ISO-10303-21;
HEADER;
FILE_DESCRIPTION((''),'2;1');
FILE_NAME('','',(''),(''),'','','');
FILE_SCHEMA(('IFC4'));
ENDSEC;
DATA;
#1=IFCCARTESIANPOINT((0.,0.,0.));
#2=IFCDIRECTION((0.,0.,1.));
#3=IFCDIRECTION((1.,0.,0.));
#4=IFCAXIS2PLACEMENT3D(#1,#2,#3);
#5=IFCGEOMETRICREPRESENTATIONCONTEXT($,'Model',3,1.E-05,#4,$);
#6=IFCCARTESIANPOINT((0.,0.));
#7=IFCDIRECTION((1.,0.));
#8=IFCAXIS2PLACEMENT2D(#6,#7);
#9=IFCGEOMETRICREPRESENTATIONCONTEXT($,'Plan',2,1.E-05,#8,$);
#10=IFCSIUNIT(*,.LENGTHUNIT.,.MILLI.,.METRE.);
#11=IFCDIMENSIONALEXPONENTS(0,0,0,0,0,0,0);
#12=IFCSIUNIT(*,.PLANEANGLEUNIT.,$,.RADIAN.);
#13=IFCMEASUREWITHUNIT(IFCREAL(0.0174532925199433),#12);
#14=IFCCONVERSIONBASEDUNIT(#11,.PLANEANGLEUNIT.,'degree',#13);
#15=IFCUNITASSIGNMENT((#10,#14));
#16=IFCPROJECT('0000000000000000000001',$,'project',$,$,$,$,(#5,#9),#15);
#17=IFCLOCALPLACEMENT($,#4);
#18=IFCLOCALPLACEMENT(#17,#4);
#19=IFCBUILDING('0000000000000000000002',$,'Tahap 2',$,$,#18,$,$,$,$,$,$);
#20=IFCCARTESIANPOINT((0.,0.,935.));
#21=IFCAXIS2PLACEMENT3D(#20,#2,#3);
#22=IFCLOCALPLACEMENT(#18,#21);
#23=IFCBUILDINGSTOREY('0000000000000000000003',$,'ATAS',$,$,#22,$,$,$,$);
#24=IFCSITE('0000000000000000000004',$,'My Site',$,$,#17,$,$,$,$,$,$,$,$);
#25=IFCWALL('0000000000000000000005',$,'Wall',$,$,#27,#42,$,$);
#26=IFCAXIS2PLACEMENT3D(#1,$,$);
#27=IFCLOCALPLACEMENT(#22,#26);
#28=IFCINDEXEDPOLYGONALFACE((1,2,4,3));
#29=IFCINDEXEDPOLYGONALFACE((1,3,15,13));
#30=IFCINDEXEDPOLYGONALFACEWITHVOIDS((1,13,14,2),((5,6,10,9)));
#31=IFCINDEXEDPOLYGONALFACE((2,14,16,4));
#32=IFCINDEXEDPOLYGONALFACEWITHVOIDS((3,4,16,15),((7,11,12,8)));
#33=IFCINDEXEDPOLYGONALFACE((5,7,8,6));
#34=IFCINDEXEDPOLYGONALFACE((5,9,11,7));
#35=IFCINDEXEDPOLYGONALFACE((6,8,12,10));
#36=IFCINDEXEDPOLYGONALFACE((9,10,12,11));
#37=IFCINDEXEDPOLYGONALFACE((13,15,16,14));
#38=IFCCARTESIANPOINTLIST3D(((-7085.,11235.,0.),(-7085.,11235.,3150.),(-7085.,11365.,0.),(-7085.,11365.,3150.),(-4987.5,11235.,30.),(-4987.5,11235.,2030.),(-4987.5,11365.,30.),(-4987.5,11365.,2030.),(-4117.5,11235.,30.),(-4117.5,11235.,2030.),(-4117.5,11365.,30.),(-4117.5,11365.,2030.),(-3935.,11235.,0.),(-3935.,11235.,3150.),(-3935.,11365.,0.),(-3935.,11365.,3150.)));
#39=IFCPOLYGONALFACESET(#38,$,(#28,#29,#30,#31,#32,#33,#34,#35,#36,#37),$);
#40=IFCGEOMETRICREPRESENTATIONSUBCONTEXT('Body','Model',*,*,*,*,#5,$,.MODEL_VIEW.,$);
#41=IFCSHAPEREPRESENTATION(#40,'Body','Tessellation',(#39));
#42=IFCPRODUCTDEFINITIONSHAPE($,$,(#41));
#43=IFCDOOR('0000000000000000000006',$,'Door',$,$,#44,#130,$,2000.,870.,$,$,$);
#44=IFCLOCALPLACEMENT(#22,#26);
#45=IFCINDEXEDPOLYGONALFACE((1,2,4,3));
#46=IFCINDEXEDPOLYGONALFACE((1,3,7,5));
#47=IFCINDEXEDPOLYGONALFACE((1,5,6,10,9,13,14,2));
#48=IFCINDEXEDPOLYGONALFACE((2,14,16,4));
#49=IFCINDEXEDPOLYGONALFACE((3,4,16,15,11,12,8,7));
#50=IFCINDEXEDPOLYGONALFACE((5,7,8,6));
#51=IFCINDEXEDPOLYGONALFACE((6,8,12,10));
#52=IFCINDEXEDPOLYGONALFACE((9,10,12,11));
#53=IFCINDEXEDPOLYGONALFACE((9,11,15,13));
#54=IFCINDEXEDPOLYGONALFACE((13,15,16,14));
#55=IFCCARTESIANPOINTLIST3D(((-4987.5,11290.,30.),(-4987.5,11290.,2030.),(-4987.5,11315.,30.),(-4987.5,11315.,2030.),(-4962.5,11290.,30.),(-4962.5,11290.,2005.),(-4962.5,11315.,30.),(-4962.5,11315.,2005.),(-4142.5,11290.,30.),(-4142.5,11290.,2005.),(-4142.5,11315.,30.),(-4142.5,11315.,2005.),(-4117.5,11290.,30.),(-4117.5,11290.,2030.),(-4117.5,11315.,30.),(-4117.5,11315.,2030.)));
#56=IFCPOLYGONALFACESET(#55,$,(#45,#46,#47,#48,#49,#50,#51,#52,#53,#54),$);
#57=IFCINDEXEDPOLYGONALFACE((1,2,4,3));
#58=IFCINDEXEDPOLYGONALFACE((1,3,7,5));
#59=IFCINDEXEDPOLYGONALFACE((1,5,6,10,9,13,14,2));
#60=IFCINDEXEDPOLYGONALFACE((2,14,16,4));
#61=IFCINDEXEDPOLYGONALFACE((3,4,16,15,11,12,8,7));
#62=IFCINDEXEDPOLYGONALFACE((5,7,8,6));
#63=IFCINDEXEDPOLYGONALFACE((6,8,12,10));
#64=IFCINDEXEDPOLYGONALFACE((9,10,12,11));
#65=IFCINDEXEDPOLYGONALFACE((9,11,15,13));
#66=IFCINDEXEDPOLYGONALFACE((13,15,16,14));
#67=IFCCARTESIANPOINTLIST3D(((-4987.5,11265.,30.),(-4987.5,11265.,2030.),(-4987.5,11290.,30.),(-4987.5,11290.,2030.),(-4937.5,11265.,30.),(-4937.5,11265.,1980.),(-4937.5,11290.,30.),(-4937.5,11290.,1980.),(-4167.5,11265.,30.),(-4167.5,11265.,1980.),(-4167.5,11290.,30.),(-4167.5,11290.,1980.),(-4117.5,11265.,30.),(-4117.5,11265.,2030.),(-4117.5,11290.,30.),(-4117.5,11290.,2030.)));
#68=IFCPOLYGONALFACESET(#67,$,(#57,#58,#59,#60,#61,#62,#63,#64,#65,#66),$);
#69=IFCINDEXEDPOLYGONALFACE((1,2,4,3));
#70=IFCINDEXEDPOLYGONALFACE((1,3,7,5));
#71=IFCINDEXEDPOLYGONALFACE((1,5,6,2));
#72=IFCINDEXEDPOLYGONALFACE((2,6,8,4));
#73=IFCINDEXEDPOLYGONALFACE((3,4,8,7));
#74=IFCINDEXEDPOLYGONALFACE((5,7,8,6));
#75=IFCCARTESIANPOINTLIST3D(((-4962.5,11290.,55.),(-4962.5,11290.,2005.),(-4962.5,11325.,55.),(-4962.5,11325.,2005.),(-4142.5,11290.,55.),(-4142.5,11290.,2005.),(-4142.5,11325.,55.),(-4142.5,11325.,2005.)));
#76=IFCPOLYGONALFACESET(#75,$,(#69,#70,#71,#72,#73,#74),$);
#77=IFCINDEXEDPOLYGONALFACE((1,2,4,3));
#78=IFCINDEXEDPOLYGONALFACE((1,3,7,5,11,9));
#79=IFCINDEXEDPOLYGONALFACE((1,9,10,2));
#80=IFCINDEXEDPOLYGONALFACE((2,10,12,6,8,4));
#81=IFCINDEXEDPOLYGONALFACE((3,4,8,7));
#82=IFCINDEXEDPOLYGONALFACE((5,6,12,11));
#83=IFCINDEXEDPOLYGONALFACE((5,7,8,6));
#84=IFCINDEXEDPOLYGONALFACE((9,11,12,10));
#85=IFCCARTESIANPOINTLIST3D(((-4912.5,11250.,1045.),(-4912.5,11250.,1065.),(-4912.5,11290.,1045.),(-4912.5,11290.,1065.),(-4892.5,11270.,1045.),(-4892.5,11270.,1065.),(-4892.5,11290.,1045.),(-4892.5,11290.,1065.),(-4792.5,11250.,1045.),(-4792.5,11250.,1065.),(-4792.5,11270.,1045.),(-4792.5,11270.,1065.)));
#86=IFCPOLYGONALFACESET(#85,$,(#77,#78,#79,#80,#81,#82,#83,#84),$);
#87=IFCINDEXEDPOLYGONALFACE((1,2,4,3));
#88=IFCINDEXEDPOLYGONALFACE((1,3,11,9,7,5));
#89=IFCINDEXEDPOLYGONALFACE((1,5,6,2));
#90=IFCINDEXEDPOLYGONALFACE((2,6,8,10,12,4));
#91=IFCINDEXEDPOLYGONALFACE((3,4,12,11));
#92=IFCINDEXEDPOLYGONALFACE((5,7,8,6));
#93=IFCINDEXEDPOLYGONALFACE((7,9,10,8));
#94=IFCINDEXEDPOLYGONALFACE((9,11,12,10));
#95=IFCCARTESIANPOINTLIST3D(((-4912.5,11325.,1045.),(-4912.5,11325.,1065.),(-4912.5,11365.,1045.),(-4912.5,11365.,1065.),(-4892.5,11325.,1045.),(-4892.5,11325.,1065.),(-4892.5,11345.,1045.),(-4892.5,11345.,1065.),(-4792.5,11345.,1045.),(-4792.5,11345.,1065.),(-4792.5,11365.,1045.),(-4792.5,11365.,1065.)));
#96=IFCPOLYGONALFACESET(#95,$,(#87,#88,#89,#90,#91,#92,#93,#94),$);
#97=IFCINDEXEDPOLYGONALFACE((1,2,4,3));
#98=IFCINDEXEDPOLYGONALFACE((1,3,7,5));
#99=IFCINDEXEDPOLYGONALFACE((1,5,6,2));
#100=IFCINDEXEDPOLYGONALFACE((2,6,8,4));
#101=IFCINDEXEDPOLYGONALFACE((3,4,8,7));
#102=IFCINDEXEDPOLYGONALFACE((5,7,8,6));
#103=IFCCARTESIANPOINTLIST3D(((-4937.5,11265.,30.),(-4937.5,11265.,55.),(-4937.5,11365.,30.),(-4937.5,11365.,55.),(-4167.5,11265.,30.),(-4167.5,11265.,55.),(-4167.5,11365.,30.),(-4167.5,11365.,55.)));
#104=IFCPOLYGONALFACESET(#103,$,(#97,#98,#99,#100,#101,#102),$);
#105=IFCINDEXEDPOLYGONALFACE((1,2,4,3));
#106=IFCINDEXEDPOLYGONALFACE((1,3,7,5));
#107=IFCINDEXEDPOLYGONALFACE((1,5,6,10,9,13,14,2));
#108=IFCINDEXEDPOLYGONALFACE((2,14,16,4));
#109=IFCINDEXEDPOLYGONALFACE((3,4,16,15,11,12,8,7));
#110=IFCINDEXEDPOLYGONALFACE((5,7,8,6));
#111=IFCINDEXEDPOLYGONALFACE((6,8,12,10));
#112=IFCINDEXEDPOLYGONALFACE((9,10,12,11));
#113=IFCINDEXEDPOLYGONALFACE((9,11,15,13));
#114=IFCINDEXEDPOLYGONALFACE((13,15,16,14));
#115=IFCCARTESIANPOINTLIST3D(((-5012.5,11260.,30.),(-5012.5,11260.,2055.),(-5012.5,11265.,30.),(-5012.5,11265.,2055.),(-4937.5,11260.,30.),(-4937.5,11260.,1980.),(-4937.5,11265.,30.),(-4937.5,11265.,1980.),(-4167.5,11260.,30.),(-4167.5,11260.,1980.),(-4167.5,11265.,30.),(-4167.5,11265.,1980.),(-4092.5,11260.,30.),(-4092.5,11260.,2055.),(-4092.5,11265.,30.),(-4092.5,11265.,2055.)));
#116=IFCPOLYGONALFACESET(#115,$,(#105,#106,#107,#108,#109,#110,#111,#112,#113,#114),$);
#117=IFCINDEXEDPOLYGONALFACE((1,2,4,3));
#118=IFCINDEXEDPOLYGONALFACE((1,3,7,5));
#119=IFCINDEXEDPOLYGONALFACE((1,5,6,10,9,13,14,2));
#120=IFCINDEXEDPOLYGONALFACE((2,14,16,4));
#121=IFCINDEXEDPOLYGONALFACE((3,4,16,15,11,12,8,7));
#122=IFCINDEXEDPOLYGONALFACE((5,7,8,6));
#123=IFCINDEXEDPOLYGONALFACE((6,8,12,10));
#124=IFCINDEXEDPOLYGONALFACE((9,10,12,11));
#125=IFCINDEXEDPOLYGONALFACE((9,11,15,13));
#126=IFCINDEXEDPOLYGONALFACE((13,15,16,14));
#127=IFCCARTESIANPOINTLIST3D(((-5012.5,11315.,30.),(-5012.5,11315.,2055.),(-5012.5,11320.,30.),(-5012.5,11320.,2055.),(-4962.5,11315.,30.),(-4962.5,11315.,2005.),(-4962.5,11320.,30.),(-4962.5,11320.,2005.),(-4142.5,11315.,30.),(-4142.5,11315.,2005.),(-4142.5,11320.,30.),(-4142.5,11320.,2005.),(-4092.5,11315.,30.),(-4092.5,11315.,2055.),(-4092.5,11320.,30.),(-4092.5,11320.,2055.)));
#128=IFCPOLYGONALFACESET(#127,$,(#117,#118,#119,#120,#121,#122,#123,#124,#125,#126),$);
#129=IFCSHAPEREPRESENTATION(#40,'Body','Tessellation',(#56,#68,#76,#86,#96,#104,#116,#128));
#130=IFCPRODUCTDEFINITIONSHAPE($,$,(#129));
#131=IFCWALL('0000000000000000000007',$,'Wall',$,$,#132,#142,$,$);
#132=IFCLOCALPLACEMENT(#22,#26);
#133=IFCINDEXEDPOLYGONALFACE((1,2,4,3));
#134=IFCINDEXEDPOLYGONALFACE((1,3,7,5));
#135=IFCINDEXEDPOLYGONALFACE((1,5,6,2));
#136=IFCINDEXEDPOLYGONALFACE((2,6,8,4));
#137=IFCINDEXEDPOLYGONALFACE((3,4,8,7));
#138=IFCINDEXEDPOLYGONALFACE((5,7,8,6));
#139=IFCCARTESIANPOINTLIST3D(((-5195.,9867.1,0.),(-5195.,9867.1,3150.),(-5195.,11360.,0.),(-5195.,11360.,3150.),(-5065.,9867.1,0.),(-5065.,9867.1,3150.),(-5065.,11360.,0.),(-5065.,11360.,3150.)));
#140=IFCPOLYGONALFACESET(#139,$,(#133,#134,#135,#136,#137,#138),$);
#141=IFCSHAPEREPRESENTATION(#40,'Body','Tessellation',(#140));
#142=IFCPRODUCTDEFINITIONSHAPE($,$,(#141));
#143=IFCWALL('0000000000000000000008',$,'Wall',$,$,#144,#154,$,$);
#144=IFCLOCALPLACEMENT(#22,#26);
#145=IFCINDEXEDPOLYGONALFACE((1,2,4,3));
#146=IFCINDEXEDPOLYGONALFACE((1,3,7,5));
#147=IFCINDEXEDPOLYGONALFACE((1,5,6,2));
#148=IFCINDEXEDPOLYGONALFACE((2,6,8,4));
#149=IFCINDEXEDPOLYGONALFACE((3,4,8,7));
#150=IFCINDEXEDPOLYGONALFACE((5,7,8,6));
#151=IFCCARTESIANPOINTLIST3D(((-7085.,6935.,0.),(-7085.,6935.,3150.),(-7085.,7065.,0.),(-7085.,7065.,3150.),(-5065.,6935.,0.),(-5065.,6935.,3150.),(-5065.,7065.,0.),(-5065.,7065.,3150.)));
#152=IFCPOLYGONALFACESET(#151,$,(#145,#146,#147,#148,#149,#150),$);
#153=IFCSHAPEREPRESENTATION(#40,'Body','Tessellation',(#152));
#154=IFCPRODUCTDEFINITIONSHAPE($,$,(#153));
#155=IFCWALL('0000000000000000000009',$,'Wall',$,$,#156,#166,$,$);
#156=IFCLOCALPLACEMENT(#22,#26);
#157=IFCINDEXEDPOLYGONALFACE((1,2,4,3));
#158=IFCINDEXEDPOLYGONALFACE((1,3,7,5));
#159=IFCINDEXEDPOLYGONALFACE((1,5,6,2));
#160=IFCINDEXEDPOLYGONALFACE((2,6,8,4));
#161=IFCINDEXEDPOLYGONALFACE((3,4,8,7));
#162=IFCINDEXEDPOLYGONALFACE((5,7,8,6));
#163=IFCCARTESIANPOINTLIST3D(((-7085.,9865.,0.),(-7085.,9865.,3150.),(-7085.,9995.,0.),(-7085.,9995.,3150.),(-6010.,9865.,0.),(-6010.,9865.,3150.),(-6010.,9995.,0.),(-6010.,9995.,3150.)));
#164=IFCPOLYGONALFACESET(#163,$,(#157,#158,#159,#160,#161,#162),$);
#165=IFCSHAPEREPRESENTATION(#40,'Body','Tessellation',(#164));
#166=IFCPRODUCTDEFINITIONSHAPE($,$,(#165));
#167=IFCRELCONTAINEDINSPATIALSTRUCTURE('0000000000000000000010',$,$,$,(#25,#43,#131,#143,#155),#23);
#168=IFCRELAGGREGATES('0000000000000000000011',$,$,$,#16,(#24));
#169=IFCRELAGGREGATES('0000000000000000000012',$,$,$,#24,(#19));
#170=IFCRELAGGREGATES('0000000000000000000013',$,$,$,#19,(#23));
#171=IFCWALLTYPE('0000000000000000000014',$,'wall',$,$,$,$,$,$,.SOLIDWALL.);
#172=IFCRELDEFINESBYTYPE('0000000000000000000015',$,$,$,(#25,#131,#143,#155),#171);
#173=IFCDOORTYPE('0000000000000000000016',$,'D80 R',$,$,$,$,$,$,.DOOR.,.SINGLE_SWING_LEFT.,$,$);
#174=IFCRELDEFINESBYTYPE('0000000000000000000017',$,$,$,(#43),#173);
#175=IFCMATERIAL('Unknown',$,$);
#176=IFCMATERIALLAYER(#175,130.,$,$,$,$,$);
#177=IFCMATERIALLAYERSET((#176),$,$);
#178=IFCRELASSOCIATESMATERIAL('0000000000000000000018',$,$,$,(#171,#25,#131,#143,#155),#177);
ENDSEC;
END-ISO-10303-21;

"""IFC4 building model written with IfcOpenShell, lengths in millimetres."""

from ifc_helpers import new_model, entity, si_unit, converted_unit, frame, origin_with_axes, origin_2d_with_axis, place, context, subcontext, project, spatial, line, indexed_curve, outline, extrude, shape, source, transform, mapped, material, layer, layer_set, layer_usage, type_object, type_shapes, element, fill, save


model = new_model("IFC4")

# Units and contexts
model_context = context("Model", 3, precision=1e-05, world=origin_with_axes())
plan_context = context("Plan", 2, precision=1e-05, world=origin_2d_with_axis())
body_context_1 = subcontext(model_context, "Body", "Model", "MODEL_VIEW")
body_context_2 = subcontext(plan_context, "Body", "Plan", "PLAN_VIEW")
ifc_project = project(units=[si_unit("LENGTHUNIT", "METRE", prefix="MILLI"), converted_unit("PLANEANGLEUNIT", "degree", entity("IfcReal", 0.0174532925199433), si_unit("PLANEANGLEUNIT", "RADIAN"), dimensions=[0, 0, 0, 0, 0, 0, 0])], contexts=[model_context, plan_context])

# Site, building, storey
site_placement = place(None, origin_with_axes())
site = spatial("IfcSite", under=ifc_project, at=site_placement, Name="My Site")
building_placement = place(site_placement, origin_with_axes())
building = spatial("IfcBuilding", under=site, at=building_placement, Name="Tahap 2")
storey_placement = place(building_placement, frame((0.0, 0.0, 935.0), z_axis=(0.0, 0.0, 1.0), x_axis=(1.0, 0.0, 0.0)))
storey = spatial("IfcBuildingStorey", under=building, at=storey_placement, Name="ATAS")

# Wall, opening, door
ifc_material_1 = material(Name="Unknown")
ifc_layer_1 = layer(ifc_material_1, 130.0)
ifc_layer_set_1 = layer_set([ifc_layer_1])
wall_type_1 = type_object("IfcWallType", Name="wall", PredefinedType="SOLIDWALL", material=ifc_layer_set_1)
shared_shape_1 = source(origin_with_axes(), body_context_1, "Body", "SweptSolid", [
    extrude(outline(indexed_curve([(0.0, 0.0), (870.0, 0.0), (870.0, 2000.0), (0.0, 2000.0)], segments=[line(1, 2, 3, 4, 1)])), frame((0.0, -600.0, 0.0), z_axis=(0.0, -1.0, 0.0), x_axis=(1.0, 0.0, 0.0)), (0.0, 0.0, -1.0), 1200.0),
])
door_type_1 = type_object("IfcDoorType", Name="D80 R", OperationType="SINGLE_SWING_LEFT", PredefinedType="DOOR")
shared_shape_2 = source(origin_with_axes(), body_context_1, "Body", "SweptSolid", [
    extrude(outline(indexed_curve([(0.0, 0.0), (0.0, 2000.0), (870.0, 2000.0), (870.0, 0.0), (845.0, 0.0), (845.0, 1975.0), (25.0, 1975.0), (25.0, 0.0)], segments=[line(1, 2, 3, 4, 5, 6, 7, 8, 1)])), frame((0.0, 25.0, 0.0), z_axis=(0.0, -1.0, 0.0), x_axis=(1.0, 0.0, 0.0)), (0.0, 0.0, -1.0), 25.0),
    extrude(outline(indexed_curve([(0.0, 0.0), (0.0, 2000.0), (870.0, 2000.0), (870.0, 0.0), (820.0, 0.0), (820.0, 1950.0), (50.0, 1950.0), (50.0, 0.0)], segments=[line(1, 2, 3, 4, 5, 6, 7, 8, 1)])), frame((0.0, 0.0, 0.0), z_axis=(0.0, -1.0, 0.0), x_axis=(1.0, 0.0, 0.0)), (0.0, 0.0, -1.0), 25.0),
    extrude(outline(indexed_curve([(0.0, 0.0), (820.0, 0.0), (820.0, 35.0), (0.0, 35.0)], segments=[line(1, 2, 3, 4, 1)])), frame((25.0, 25.0, 25.0), z_axis=(0.0, 0.0, 1.0), x_axis=(1.0, 0.0, 0.0)), (0.0, 0.0, 1.0), 1950.0),
    extrude(outline(indexed_curve([(0.0, 0.0), (0.0, -40.0), (120.0, -40.0), (120.0, -20.0), (20.0, -20.0), (20.0, 0.0)], segments=[line(1, 2, 3, 4, 5, 6, 1)])), frame((75.0, 25.0, 1015.0), z_axis=(0.0, 0.0, 1.0), x_axis=(1.0, 0.0, 0.0)), (0.0, 0.0, 1.0), 20.0),
    extrude(outline(indexed_curve([(0.0, 0.0), (0.0, 40.0), (120.0, 40.0), (120.0, 20.0), (20.0, 20.0), (20.0, 0.0)], segments=[line(1, 2, 3, 4, 5, 6, 1)])), frame((75.0, 60.0, 1015.0), z_axis=(0.0, 0.0, 1.0), x_axis=(1.0, 0.0, 0.0)), (0.0, 0.0, 1.0), 20.0),
    extrude(outline(indexed_curve([(0.0, 0.0), (770.0, 0.0), (770.0, 100.0), (0.0, 100.0)], segments=[line(1, 2, 3, 4, 1)])), frame((50.0, 0.0, 0.0), z_axis=(0.0, 0.0, 1.0), x_axis=(1.0, 0.0, 0.0)), (0.0, 0.0, 1.0), 25.0),
    extrude(outline(indexed_curve([(0.0, 0.0), (0.0, 2025.0), (920.0, 2025.0), (920.0, 0.0), (845.0, 0.0), (845.0, 1950.0), (75.0, 1950.0), (75.0, 0.0)], segments=[line(1, 2, 3, 4, 5, 6, 7, 8, 1)])), frame((-25.0, -5.0, 0.0), z_axis=(0.0, -1.0, 0.0), x_axis=(1.0, 0.0, 0.0)), (0.0, 0.0, -1.0), 5.0),
    extrude(outline(indexed_curve([(0.0, 0.0), (0.0, 2025.0), (920.0, 2025.0), (920.0, 0.0), (870.0, 0.0), (870.0, 1975.0), (50.0, 1975.0), (50.0, 0.0)], segments=[line(1, 2, 3, 4, 5, 6, 7, 8, 1)])), frame((-25.0, 50.0, 0.0), z_axis=(0.0, -1.0, 0.0), x_axis=(1.0, 0.0, 0.0)), (0.0, 0.0, -1.0), 5.0),
])
shared_shape_3 = source(origin_with_axes(), body_context_2, "Body", "Curve2D", [
    entity("IfcIndexedPolyCurve", entity("IfcCartesianPointList2D", [[0.0, 0.0], [0.0, 50.0], [25.0, 50.0], [25.0, 25.0], [50.0, 25.0], [50.0, 0.0]]), [entity("IfcLineIndex", [1, 2, 3, 4, 5, 6, 1])]),
    entity("IfcIndexedPolyCurve", entity("IfcCartesianPointList2D", [[870.0, 0.0], [870.0, 50.0], [845.0, 50.0], [845.0, 25.0], [820.0, 25.0], [820.0, 0.0]]), [entity("IfcLineIndex", [1, 2, 3, 4, 5, 6, 1])]),
    entity("IfcTrimmedCurve", entity("IfcEllipse", entity("IfcAxis2Placement2D", entity("IfcCartesianPoint", [810.0, 50.0]), entity("IfcDirection", [1.0, 0.0])), 785.0, 820.0), [entity("IfcCartesianPoint", [810.0, 870.0])], [entity("IfcCartesianPoint", [25.0, 50.0])], True, "CARTESIAN"),
    entity("IfcIndexedPolyCurve", entity("IfcCartesianPointList2D", [[845.0, 50.0], [810.0, 50.0], [810.0, 870.0], [845.0, 870.0]]), [entity("IfcLineIndex", [1, 2, 3, 4, 1])]),
])
type_shapes(door_type_1, [shared_shape_2, shared_shape_3])
ifc_layer_usage_1 = layer_usage(ifc_layer_set_1, "AXIS2", "NEGATIVE", 0.0)
wall_1_placement = place(storey_placement, frame((-3935.0, 11235.0, 0.0), z_axis=(0.0, 0.0, 1.0), x_axis=(-1.0, 0.0, 0.0)))
wall_1 = element("IfcWall", 1, at=wall_1_placement, inside=storey, type_object=wall_type_1, material=ifc_layer_usage_1, Name="Wall", context=body_context_1, shape_type="SweptSolid", body=[
    extrude(outline(indexed_curve([(0.0, -130.0), (0.0, 0.0), (3150.0, 0.0), (3150.0, -130.0)], segments=[line(1, 2, 3, 4, 1)])), origin_with_axes(), (0.0, 0.0, 1.0), 3150.0),
])
opening_1_placement = place(wall_1_placement, frame((1052.5, -30.0, 30.0), z_axis=(0.0, 0.0, 1.0), x_axis=(-1.0, 0.0, 0.0)))
opening_1 = element("IfcOpeningElement", 2, at=opening_1_placement, cuts=wall_1, PredefinedType="OPENING", context=body_context_1, shape_type="MappedRepresentation", body=[
    mapped(shared_shape_1, transform((0.0, 0.0, 0.0), x_axis=(1.0, 0.0, 0.0), y_axis=(0.0, 1.0, 0.0), z_axis=(0.0, 0.0, 1.0), scale=1.0)),
])
door_1_placement = place(opening_1_placement, frame((0.0, 0.0, 0.0), z_axis=(0.0, 0.0, 1.0), x_axis=(1.0, 0.0, 0.0)))
door_1 = element("IfcDoor", 3, at=door_1_placement, inside=storey, type_object=door_type_1, Name="Door", OverallHeight=2000.0, OverallWidth=870.0, shapes=[
    shape(body_context_1, "Body", "MappedRepresentation", [mapped(shared_shape_2, transform((0.0, 0.0, 0.0), x_axis=(1.0, 0.0, 0.0), y_axis=(0.0, 1.0, 0.0), z_axis=(0.0, 0.0, 1.0), scale=1.0))]),
    shape(body_context_2, "Body", "MappedRepresentation", [mapped(shared_shape_3, transform((0.0, 0.0, 0.0), x_axis=(1.0, 0.0, 0.0), y_axis=(0.0, 1.0, 0.0), z_axis=(0.0, 0.0, 1.0), scale=1.0))]),
])
fill(opening_1, door_1)

# Walls
ifc_layer_usage_2 = layer_usage(ifc_layer_set_1, "AXIS2", "POSITIVE", 0.0)
wall_2_placement = place(storey_placement, frame((-5195.0, 11360.0, 0.0), z_axis=(0.0, 0.0, 1.0), x_axis=(0.0, -1.0, 0.0)))
element("IfcWall", 4, at=wall_2_placement, inside=storey, type_object=wall_type_1, material=ifc_layer_usage_2, Name="Wall", context=body_context_1, shape_type="SweptSolid", body=[
    extrude(outline(indexed_curve([(0.0, 0.0), (0.0, 130.0), (1492.8, 130.0), (1492.8, 0.0)], segments=[line(1, 2, 3, 4, 1)])), origin_with_axes(), (0.0, 0.0, 1.0), 3150.0),
])
ifc_layer_usage_3 = layer_usage(ifc_layer_set_1, "AXIS2", "POSITIVE", 0.0)
wall_3_placement = place(storey_placement, frame((-5065.0, 7065.0, 0.0), z_axis=(0.0, 0.0, 1.0), x_axis=(-1.0, 0.0, 0.0)))
element("IfcWall", 5, at=wall_3_placement, inside=storey, type_object=wall_type_1, material=ifc_layer_usage_3, Name="Wall", context=body_context_1, shape_type="SweptSolid", body=[
    extrude(outline(indexed_curve([(0.0, 0.0), (0.0, 130.0), (2020.0, 130.0), (2020.0, 0.0)], segments=[line(1, 2, 3, 4, 1)])), origin_with_axes(), (0.0, 0.0, 1.0), 3150.0),
])
ifc_layer_usage_4 = layer_usage(ifc_layer_set_1, "AXIS2", "POSITIVE", 0.0)
wall_4_placement = place(storey_placement, frame((-7085.0, 9865.0, 0.0), z_axis=(0.0, 0.0, 1.0), x_axis=(1.0, 0.0, 0.0)))
element("IfcWall", 6, at=wall_4_placement, inside=storey, type_object=wall_type_1, material=ifc_layer_usage_4, Name="Wall", context=body_context_1, shape_type="SweptSolid", body=[
    extrude(outline(indexed_curve([(0.0, 0.0), (0.0, 130.0), (1075.0, 130.0), (1075.0, 0.0)], segments=[line(1, 2, 3, 4, 1)])), origin_with_axes(), (0.0, 0.0, 1.0), 3150.0),
])

save(model, "model.ifc")
